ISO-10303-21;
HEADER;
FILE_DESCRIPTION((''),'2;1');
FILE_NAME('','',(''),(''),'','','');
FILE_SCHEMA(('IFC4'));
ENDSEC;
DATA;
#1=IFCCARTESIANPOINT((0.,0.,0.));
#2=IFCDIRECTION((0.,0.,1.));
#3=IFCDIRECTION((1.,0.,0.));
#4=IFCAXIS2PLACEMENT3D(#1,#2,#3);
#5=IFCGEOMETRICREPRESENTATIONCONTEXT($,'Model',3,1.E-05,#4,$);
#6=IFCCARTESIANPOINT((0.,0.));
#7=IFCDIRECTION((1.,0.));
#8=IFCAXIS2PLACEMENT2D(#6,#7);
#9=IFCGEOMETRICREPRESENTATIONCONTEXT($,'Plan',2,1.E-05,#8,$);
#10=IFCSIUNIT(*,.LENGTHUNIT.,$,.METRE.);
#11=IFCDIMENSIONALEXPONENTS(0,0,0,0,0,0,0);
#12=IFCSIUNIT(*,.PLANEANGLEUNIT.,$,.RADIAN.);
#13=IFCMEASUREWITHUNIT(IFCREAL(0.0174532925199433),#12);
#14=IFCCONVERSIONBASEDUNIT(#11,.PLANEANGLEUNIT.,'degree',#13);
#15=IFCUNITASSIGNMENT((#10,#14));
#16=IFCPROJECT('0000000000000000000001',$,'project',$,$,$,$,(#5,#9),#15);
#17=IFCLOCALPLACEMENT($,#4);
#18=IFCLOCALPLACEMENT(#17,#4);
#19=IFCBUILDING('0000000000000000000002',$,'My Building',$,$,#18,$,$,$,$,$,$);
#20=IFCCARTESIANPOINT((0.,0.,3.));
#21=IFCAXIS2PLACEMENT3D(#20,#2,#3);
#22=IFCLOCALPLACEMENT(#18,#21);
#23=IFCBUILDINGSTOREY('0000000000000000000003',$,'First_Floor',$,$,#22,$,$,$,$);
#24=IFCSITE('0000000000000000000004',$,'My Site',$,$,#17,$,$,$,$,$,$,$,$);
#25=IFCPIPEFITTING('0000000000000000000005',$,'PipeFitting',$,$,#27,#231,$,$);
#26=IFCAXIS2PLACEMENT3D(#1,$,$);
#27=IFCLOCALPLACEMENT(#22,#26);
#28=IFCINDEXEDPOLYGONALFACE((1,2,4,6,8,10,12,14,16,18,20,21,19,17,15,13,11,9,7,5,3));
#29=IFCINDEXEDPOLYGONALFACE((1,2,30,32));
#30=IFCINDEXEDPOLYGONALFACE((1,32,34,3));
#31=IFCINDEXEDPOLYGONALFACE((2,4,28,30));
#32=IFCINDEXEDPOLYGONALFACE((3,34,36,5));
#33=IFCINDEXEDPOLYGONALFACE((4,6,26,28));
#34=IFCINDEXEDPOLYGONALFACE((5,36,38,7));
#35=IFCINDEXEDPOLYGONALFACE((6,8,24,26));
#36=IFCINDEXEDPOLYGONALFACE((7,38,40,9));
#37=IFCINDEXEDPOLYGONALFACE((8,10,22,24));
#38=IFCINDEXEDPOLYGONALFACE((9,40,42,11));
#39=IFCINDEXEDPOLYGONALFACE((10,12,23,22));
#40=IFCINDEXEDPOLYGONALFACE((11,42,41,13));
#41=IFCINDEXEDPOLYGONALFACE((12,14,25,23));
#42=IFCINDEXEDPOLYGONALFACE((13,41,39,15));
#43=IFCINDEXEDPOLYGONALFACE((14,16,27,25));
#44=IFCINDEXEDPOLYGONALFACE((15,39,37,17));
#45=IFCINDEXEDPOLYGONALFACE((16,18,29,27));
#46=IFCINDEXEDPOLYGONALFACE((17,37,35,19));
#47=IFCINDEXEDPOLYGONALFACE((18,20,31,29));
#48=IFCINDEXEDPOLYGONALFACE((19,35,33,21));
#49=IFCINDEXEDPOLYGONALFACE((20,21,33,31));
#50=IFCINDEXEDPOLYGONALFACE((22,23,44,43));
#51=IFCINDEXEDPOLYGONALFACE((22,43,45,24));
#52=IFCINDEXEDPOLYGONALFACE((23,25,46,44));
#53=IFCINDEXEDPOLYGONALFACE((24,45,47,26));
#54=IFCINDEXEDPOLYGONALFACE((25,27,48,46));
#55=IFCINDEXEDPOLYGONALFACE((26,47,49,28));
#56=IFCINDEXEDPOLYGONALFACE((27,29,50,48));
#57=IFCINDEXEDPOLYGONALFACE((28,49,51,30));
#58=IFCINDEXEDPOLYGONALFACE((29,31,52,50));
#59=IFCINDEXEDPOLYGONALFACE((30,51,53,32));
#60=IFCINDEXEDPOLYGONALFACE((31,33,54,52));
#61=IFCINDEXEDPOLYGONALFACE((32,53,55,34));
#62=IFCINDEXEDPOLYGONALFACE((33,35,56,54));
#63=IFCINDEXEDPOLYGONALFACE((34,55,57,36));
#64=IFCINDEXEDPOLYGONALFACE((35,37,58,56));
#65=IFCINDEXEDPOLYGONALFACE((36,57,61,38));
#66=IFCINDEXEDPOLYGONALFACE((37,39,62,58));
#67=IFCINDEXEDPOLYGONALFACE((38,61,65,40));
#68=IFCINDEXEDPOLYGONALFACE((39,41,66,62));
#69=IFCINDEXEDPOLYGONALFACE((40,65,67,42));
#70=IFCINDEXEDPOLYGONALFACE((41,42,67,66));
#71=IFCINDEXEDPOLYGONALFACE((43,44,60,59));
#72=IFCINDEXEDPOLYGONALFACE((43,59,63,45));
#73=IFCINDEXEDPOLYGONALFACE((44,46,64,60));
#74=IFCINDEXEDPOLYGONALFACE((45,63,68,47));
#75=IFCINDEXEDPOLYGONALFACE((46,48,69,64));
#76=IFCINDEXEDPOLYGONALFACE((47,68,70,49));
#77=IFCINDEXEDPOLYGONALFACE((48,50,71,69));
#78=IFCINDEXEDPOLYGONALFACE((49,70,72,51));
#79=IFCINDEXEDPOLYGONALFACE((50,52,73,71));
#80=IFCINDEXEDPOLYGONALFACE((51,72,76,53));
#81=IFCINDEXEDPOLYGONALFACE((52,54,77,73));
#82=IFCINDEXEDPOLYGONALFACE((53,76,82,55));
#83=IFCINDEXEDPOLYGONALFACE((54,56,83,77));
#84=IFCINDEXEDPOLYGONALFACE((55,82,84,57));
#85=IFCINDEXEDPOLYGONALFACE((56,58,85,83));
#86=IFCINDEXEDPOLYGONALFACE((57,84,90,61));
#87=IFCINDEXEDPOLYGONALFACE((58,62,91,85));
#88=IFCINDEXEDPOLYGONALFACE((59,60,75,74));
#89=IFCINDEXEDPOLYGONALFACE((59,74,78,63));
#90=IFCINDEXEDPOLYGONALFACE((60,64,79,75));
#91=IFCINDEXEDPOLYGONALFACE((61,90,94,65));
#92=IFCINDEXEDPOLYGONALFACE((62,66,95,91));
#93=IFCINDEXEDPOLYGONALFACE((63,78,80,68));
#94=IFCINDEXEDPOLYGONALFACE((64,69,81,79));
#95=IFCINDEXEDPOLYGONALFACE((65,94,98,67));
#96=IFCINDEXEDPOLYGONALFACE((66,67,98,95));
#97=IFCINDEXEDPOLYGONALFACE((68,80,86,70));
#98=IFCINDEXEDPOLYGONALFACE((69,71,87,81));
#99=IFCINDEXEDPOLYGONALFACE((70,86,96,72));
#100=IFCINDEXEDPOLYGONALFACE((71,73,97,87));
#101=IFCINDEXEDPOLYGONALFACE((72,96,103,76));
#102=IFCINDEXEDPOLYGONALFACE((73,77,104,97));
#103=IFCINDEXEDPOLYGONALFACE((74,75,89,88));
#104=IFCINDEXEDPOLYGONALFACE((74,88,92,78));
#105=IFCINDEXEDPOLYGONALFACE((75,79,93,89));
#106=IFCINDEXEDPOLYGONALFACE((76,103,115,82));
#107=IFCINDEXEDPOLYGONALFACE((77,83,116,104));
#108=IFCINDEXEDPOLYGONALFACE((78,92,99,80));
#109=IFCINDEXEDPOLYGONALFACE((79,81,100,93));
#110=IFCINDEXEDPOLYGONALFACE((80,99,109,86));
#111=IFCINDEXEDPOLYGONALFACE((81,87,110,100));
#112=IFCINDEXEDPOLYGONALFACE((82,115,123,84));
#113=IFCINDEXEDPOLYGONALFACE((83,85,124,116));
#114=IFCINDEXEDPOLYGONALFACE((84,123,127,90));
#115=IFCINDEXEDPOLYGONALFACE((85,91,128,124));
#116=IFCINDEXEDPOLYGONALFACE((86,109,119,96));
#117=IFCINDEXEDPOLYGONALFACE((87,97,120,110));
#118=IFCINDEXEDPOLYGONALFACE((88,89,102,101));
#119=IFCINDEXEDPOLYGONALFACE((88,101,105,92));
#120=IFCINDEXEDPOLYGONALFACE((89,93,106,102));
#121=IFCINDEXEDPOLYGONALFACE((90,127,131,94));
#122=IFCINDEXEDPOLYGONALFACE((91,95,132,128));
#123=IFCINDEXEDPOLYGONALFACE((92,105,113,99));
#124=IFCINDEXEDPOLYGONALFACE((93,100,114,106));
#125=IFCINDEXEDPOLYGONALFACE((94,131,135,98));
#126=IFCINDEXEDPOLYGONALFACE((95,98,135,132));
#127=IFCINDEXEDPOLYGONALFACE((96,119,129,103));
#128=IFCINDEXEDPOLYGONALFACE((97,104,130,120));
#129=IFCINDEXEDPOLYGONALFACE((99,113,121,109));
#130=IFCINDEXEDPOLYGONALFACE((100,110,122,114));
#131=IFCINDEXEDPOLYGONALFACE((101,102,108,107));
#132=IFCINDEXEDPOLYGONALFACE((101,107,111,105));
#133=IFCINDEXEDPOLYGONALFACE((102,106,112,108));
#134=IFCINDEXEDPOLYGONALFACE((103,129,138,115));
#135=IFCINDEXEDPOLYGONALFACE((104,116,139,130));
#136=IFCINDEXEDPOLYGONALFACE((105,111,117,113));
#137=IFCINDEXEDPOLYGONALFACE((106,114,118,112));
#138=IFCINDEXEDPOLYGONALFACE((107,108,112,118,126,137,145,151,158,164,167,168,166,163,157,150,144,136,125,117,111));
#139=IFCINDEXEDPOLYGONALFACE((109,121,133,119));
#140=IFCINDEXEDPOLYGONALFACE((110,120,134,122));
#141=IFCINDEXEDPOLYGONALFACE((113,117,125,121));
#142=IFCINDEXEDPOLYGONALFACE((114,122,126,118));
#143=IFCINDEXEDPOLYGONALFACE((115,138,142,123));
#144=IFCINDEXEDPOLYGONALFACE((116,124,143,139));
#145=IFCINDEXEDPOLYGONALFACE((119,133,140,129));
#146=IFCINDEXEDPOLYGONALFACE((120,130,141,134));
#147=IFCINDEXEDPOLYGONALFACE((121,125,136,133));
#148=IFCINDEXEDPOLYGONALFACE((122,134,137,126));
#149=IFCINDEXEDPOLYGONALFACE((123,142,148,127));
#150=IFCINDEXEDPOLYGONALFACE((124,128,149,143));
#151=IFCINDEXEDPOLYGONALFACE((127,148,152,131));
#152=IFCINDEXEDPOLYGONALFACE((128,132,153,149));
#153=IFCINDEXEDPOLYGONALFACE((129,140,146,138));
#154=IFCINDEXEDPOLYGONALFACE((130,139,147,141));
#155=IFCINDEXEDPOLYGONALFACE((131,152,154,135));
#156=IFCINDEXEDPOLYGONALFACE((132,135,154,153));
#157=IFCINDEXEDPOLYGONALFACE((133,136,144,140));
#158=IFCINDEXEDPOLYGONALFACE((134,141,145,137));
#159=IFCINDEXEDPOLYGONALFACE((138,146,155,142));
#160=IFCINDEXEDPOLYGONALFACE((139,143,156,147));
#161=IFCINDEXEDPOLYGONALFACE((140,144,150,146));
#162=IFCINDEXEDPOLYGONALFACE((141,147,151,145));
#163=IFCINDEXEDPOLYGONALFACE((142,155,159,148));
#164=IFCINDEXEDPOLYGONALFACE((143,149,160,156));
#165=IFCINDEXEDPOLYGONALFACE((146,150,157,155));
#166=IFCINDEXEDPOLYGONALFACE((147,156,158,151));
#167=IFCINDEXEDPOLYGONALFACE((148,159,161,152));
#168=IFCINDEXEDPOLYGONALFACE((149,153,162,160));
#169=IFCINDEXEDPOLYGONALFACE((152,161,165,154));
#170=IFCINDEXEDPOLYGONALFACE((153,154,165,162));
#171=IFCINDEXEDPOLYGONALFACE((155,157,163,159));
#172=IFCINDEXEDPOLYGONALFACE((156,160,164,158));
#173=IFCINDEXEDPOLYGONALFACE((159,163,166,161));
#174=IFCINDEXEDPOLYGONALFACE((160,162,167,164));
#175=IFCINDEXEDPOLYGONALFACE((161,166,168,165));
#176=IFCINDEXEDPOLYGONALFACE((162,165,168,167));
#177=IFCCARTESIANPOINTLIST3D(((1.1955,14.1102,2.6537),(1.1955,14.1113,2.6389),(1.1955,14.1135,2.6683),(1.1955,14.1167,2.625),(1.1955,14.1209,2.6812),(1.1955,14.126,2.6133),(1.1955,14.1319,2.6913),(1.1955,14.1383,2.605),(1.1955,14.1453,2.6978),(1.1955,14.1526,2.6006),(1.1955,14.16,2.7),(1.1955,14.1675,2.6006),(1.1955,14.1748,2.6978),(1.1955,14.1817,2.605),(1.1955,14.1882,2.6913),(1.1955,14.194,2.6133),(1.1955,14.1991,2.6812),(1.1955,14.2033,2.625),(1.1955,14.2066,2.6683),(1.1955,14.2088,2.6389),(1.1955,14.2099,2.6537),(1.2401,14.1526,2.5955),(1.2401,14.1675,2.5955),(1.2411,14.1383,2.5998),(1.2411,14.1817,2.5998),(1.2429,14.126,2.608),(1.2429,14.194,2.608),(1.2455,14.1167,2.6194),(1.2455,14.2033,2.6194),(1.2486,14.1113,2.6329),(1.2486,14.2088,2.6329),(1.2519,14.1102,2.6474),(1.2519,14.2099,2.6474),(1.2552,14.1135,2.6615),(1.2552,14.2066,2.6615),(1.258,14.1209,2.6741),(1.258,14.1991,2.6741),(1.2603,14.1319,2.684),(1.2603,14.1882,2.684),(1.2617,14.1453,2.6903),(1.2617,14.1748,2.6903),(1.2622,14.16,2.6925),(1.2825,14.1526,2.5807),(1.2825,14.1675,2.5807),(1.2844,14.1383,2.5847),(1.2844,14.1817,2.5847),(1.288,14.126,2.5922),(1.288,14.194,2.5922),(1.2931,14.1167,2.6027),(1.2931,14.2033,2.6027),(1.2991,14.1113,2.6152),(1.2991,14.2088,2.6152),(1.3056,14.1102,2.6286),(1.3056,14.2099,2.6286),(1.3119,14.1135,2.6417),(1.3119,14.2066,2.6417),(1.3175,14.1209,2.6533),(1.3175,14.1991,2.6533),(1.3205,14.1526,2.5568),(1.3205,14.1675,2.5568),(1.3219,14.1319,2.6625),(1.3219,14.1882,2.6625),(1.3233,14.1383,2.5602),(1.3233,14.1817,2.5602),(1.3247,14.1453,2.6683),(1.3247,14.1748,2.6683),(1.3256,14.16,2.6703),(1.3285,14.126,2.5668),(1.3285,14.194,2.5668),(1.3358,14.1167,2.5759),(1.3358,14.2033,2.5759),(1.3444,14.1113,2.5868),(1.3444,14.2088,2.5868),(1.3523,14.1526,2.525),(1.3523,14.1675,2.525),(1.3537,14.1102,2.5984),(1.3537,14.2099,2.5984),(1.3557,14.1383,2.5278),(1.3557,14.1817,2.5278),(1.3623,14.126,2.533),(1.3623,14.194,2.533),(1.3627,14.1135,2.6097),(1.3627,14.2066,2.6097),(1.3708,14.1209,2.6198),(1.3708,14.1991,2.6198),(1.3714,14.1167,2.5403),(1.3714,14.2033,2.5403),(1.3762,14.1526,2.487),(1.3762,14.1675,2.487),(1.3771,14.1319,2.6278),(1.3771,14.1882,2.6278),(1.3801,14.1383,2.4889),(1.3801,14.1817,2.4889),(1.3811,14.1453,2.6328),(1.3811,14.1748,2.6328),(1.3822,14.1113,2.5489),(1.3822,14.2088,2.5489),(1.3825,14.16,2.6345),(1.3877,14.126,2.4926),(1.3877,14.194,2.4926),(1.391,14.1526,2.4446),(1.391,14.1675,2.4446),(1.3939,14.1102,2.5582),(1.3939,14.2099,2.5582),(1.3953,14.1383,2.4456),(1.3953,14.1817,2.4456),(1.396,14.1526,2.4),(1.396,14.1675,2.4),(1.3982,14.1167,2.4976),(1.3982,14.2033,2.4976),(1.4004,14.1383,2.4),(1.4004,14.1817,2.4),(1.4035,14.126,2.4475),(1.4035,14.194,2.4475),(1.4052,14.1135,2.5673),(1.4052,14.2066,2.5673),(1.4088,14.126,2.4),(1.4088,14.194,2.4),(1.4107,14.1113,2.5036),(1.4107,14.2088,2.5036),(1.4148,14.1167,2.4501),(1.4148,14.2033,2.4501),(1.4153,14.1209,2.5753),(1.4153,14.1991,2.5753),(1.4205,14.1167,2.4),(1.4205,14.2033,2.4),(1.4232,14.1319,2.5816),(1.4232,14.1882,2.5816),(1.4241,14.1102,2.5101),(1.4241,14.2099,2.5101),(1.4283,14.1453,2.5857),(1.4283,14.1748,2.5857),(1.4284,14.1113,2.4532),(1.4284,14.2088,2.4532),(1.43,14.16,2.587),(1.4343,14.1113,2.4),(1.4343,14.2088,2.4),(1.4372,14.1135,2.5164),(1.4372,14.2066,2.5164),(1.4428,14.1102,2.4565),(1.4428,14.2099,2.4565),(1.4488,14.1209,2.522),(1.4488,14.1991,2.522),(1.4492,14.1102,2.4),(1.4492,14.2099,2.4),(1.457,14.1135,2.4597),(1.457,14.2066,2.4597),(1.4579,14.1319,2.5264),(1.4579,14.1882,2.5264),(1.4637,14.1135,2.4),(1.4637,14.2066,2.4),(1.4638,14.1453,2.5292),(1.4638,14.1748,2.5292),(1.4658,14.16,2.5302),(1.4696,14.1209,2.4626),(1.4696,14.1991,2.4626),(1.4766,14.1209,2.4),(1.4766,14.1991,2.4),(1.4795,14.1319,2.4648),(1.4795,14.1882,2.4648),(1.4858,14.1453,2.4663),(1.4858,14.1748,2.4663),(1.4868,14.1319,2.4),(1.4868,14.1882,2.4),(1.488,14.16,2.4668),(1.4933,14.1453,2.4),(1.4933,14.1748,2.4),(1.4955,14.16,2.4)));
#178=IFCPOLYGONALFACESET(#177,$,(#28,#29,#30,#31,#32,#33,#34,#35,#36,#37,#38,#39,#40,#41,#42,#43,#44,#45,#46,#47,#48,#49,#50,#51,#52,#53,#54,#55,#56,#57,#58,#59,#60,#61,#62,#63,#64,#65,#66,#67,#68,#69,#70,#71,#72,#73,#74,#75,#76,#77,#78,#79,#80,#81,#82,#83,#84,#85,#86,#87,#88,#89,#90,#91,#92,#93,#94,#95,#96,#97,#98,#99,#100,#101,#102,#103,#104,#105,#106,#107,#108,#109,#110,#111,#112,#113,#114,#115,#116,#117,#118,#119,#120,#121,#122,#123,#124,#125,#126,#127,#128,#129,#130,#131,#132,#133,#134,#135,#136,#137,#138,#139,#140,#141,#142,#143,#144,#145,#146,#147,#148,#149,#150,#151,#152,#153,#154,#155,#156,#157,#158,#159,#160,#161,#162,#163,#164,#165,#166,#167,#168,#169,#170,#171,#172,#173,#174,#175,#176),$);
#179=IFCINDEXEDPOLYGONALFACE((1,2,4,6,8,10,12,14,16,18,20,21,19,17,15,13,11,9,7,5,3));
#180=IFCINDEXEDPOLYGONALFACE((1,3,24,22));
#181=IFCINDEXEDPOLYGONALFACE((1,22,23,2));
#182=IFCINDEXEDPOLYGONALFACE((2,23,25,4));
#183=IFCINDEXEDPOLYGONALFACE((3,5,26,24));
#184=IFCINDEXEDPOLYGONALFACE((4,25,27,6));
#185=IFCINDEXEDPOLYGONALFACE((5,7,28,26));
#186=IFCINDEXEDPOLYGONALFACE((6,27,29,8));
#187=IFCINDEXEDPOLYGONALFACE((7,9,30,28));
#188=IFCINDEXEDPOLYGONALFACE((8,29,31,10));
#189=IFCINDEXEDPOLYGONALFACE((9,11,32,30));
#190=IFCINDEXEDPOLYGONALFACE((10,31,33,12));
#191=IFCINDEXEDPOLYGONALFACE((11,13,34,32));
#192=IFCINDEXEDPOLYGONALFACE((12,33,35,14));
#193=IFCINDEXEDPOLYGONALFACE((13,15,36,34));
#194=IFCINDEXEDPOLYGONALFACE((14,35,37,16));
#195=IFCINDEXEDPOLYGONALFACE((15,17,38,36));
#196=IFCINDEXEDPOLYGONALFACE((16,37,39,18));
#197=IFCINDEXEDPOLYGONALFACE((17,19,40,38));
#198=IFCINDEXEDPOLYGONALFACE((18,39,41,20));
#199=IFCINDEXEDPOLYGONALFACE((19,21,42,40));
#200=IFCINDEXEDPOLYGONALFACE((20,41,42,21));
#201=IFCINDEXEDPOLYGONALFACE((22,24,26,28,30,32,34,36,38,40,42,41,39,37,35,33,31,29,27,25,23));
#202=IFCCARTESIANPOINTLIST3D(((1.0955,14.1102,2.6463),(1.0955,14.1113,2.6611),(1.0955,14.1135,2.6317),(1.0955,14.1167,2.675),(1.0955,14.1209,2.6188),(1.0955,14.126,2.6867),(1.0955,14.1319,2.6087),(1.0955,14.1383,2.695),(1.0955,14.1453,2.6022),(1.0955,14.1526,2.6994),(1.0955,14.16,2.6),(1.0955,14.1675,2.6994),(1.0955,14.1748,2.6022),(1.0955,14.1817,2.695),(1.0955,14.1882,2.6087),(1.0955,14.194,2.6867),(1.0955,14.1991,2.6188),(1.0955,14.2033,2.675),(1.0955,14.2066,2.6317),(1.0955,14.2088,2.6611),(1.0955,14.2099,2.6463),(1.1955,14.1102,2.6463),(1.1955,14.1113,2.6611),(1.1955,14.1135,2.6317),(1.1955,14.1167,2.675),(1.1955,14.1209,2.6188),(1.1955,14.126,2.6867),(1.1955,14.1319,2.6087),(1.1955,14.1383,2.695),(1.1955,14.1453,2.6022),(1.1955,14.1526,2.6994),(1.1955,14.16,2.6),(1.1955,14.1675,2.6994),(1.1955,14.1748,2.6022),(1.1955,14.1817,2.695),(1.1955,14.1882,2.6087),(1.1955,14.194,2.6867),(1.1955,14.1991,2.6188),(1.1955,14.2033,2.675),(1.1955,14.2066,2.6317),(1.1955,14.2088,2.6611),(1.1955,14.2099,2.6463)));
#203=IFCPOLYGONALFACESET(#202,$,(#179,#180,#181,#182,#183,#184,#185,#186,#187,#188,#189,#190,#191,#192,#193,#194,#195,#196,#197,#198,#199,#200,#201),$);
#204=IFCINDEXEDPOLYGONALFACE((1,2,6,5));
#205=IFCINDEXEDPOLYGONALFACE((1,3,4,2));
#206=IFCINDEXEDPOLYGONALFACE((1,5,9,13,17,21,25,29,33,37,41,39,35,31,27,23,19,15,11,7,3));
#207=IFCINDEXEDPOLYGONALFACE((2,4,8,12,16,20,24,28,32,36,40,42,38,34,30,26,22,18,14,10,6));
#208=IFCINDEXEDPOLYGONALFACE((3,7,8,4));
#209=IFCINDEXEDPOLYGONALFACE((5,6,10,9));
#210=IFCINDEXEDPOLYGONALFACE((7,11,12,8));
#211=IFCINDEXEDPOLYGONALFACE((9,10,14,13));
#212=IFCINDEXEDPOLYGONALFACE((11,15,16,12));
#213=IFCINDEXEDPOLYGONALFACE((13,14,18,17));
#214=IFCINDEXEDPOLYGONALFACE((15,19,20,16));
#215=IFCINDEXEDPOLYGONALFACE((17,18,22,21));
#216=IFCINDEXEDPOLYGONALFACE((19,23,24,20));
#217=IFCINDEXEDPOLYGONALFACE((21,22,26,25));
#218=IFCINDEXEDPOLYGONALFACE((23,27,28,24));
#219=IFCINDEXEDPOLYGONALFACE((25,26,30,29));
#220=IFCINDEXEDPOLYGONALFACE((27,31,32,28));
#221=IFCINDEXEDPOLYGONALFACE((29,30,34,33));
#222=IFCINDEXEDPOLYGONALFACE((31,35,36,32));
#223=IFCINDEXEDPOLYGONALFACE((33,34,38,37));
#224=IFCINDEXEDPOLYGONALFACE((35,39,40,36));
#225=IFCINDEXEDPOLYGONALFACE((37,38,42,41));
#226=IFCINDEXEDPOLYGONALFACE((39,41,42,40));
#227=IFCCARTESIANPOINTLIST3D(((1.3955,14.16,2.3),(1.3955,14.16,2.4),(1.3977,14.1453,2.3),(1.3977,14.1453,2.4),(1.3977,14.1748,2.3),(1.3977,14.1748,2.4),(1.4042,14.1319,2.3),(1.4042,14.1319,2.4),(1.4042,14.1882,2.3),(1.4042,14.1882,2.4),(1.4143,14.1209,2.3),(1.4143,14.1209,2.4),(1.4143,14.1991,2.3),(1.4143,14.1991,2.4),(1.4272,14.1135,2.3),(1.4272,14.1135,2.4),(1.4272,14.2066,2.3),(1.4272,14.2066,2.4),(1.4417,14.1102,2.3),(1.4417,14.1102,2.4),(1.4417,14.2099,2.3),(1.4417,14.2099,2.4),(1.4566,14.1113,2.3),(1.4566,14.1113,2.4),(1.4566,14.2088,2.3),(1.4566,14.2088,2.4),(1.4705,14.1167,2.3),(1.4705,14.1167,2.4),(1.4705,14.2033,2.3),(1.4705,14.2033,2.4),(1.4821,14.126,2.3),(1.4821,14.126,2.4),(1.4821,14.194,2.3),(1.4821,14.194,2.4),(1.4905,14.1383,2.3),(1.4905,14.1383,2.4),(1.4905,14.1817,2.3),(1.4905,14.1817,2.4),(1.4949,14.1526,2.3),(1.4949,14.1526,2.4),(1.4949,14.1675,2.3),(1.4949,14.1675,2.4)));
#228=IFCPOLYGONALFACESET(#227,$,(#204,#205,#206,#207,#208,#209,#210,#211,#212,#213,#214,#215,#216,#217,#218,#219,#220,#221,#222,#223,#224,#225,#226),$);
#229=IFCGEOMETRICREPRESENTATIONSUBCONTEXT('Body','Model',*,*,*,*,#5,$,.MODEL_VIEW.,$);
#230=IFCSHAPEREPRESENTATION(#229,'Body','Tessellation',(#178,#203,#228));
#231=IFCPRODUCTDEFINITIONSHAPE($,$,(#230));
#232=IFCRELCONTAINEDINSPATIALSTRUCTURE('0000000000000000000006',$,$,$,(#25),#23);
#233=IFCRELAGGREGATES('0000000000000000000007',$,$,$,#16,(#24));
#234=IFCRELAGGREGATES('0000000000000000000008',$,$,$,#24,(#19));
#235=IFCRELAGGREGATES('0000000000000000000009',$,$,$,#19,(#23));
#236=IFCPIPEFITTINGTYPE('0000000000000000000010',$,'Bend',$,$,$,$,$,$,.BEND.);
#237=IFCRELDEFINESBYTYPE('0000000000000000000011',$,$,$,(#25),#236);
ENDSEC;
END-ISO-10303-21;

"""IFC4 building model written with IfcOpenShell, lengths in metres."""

from ifc_helpers import new_model, entity, si_unit, converted_unit, frame, origin_with_axes, origin_2d_with_axis, place, context, subcontext, project, spatial, circle, extrude, source, transform, mapped, type_object, type_shapes, element, save


model = new_model("IFC4")

# Units and contexts
model_context = context("Model", 3, precision=1e-05, world=origin_with_axes())
plan_context = context("Plan", 2, precision=1e-05, world=origin_2d_with_axis())
body_context = subcontext(model_context, "Body", "Model", "MODEL_VIEW")
ifc_project = project(units=[si_unit("LENGTHUNIT", "METRE"), converted_unit("PLANEANGLEUNIT", "degree", entity("IfcReal", 0.0174532925199433), si_unit("PLANEANGLEUNIT", "RADIAN"), dimensions=[0, 0, 0, 0, 0, 0, 0])], contexts=[model_context, plan_context])

# Site, building, storey
site_placement = place(None, origin_with_axes())
site = spatial("IfcSite", under=ifc_project, at=site_placement, Name="My Site")
building_placement = place(site_placement, origin_with_axes())
building = spatial("IfcBuilding", under=site, at=building_placement, Name="My Building")
storey_placement = place(building_placement, frame((0.0, 0.0, 3.0), z_axis=(0.0, 0.0, 1.0), x_axis=(1.0, 0.0, 0.0)))
storey = spatial("IfcBuildingStorey", under=building, at=storey_placement, Name="First_Floor")

# Pipe fitting
pipe_fitting_type = type_object("IfcPipeFittingType", Name="Bend", PredefinedType="BEND")
shared_shape = source(origin_with_axes(), body_context, "Body", "SolidModel", [
    entity("IfcSweptDiskSolid", entity("IfcIndexedPolyCurve", entity("IfcCartesianPointList3D", [[0.0, 0.0, -0.1], [0.0732, 0.0, -0.2768], [0.25, 0.0, -0.35]]), [entity("IfcArcIndex", [1, 2, 3])]), 0.05),
    extrude(circle(Radius=0.05), origin_with_axes(), (0.0, 0.0, -1.0), 0.1),
    extrude(circle(Radius=0.05), frame((0.25, 0.0, -0.35), z_axis=(1.0, 0.0, 0.0), x_axis=(0.0, 0.0, 1.0)), (0.0, 0.0, 1.0), 0.1),
])
type_shapes(pipe_fitting_type, [shared_shape])
for number, where, z_axis, x_axis, name in (
    (1, (1.0955, 14.16, 2.65), (-1.0, 0.0, 0.0), (0.0, 0.0, -1.0), "PipeFitting"),
):
    element("IfcPipeFitting", number, at=place(storey_placement, frame(where, z_axis=z_axis, x_axis=x_axis)), inside=storey, type_object=pipe_fitting_type, Name=name, context=body_context, shape_type="MappedRepresentation", body=[
        mapped(shared_shape, transform((0.0, 0.0, 0.0), x_axis=(1.0, 0.0, 0.0), y_axis=(0.0, 1.0, 0.0), z_axis=(0.0, 0.0, 1.0), scale=1.0)),
    ])

save(model, "model.ifc")
